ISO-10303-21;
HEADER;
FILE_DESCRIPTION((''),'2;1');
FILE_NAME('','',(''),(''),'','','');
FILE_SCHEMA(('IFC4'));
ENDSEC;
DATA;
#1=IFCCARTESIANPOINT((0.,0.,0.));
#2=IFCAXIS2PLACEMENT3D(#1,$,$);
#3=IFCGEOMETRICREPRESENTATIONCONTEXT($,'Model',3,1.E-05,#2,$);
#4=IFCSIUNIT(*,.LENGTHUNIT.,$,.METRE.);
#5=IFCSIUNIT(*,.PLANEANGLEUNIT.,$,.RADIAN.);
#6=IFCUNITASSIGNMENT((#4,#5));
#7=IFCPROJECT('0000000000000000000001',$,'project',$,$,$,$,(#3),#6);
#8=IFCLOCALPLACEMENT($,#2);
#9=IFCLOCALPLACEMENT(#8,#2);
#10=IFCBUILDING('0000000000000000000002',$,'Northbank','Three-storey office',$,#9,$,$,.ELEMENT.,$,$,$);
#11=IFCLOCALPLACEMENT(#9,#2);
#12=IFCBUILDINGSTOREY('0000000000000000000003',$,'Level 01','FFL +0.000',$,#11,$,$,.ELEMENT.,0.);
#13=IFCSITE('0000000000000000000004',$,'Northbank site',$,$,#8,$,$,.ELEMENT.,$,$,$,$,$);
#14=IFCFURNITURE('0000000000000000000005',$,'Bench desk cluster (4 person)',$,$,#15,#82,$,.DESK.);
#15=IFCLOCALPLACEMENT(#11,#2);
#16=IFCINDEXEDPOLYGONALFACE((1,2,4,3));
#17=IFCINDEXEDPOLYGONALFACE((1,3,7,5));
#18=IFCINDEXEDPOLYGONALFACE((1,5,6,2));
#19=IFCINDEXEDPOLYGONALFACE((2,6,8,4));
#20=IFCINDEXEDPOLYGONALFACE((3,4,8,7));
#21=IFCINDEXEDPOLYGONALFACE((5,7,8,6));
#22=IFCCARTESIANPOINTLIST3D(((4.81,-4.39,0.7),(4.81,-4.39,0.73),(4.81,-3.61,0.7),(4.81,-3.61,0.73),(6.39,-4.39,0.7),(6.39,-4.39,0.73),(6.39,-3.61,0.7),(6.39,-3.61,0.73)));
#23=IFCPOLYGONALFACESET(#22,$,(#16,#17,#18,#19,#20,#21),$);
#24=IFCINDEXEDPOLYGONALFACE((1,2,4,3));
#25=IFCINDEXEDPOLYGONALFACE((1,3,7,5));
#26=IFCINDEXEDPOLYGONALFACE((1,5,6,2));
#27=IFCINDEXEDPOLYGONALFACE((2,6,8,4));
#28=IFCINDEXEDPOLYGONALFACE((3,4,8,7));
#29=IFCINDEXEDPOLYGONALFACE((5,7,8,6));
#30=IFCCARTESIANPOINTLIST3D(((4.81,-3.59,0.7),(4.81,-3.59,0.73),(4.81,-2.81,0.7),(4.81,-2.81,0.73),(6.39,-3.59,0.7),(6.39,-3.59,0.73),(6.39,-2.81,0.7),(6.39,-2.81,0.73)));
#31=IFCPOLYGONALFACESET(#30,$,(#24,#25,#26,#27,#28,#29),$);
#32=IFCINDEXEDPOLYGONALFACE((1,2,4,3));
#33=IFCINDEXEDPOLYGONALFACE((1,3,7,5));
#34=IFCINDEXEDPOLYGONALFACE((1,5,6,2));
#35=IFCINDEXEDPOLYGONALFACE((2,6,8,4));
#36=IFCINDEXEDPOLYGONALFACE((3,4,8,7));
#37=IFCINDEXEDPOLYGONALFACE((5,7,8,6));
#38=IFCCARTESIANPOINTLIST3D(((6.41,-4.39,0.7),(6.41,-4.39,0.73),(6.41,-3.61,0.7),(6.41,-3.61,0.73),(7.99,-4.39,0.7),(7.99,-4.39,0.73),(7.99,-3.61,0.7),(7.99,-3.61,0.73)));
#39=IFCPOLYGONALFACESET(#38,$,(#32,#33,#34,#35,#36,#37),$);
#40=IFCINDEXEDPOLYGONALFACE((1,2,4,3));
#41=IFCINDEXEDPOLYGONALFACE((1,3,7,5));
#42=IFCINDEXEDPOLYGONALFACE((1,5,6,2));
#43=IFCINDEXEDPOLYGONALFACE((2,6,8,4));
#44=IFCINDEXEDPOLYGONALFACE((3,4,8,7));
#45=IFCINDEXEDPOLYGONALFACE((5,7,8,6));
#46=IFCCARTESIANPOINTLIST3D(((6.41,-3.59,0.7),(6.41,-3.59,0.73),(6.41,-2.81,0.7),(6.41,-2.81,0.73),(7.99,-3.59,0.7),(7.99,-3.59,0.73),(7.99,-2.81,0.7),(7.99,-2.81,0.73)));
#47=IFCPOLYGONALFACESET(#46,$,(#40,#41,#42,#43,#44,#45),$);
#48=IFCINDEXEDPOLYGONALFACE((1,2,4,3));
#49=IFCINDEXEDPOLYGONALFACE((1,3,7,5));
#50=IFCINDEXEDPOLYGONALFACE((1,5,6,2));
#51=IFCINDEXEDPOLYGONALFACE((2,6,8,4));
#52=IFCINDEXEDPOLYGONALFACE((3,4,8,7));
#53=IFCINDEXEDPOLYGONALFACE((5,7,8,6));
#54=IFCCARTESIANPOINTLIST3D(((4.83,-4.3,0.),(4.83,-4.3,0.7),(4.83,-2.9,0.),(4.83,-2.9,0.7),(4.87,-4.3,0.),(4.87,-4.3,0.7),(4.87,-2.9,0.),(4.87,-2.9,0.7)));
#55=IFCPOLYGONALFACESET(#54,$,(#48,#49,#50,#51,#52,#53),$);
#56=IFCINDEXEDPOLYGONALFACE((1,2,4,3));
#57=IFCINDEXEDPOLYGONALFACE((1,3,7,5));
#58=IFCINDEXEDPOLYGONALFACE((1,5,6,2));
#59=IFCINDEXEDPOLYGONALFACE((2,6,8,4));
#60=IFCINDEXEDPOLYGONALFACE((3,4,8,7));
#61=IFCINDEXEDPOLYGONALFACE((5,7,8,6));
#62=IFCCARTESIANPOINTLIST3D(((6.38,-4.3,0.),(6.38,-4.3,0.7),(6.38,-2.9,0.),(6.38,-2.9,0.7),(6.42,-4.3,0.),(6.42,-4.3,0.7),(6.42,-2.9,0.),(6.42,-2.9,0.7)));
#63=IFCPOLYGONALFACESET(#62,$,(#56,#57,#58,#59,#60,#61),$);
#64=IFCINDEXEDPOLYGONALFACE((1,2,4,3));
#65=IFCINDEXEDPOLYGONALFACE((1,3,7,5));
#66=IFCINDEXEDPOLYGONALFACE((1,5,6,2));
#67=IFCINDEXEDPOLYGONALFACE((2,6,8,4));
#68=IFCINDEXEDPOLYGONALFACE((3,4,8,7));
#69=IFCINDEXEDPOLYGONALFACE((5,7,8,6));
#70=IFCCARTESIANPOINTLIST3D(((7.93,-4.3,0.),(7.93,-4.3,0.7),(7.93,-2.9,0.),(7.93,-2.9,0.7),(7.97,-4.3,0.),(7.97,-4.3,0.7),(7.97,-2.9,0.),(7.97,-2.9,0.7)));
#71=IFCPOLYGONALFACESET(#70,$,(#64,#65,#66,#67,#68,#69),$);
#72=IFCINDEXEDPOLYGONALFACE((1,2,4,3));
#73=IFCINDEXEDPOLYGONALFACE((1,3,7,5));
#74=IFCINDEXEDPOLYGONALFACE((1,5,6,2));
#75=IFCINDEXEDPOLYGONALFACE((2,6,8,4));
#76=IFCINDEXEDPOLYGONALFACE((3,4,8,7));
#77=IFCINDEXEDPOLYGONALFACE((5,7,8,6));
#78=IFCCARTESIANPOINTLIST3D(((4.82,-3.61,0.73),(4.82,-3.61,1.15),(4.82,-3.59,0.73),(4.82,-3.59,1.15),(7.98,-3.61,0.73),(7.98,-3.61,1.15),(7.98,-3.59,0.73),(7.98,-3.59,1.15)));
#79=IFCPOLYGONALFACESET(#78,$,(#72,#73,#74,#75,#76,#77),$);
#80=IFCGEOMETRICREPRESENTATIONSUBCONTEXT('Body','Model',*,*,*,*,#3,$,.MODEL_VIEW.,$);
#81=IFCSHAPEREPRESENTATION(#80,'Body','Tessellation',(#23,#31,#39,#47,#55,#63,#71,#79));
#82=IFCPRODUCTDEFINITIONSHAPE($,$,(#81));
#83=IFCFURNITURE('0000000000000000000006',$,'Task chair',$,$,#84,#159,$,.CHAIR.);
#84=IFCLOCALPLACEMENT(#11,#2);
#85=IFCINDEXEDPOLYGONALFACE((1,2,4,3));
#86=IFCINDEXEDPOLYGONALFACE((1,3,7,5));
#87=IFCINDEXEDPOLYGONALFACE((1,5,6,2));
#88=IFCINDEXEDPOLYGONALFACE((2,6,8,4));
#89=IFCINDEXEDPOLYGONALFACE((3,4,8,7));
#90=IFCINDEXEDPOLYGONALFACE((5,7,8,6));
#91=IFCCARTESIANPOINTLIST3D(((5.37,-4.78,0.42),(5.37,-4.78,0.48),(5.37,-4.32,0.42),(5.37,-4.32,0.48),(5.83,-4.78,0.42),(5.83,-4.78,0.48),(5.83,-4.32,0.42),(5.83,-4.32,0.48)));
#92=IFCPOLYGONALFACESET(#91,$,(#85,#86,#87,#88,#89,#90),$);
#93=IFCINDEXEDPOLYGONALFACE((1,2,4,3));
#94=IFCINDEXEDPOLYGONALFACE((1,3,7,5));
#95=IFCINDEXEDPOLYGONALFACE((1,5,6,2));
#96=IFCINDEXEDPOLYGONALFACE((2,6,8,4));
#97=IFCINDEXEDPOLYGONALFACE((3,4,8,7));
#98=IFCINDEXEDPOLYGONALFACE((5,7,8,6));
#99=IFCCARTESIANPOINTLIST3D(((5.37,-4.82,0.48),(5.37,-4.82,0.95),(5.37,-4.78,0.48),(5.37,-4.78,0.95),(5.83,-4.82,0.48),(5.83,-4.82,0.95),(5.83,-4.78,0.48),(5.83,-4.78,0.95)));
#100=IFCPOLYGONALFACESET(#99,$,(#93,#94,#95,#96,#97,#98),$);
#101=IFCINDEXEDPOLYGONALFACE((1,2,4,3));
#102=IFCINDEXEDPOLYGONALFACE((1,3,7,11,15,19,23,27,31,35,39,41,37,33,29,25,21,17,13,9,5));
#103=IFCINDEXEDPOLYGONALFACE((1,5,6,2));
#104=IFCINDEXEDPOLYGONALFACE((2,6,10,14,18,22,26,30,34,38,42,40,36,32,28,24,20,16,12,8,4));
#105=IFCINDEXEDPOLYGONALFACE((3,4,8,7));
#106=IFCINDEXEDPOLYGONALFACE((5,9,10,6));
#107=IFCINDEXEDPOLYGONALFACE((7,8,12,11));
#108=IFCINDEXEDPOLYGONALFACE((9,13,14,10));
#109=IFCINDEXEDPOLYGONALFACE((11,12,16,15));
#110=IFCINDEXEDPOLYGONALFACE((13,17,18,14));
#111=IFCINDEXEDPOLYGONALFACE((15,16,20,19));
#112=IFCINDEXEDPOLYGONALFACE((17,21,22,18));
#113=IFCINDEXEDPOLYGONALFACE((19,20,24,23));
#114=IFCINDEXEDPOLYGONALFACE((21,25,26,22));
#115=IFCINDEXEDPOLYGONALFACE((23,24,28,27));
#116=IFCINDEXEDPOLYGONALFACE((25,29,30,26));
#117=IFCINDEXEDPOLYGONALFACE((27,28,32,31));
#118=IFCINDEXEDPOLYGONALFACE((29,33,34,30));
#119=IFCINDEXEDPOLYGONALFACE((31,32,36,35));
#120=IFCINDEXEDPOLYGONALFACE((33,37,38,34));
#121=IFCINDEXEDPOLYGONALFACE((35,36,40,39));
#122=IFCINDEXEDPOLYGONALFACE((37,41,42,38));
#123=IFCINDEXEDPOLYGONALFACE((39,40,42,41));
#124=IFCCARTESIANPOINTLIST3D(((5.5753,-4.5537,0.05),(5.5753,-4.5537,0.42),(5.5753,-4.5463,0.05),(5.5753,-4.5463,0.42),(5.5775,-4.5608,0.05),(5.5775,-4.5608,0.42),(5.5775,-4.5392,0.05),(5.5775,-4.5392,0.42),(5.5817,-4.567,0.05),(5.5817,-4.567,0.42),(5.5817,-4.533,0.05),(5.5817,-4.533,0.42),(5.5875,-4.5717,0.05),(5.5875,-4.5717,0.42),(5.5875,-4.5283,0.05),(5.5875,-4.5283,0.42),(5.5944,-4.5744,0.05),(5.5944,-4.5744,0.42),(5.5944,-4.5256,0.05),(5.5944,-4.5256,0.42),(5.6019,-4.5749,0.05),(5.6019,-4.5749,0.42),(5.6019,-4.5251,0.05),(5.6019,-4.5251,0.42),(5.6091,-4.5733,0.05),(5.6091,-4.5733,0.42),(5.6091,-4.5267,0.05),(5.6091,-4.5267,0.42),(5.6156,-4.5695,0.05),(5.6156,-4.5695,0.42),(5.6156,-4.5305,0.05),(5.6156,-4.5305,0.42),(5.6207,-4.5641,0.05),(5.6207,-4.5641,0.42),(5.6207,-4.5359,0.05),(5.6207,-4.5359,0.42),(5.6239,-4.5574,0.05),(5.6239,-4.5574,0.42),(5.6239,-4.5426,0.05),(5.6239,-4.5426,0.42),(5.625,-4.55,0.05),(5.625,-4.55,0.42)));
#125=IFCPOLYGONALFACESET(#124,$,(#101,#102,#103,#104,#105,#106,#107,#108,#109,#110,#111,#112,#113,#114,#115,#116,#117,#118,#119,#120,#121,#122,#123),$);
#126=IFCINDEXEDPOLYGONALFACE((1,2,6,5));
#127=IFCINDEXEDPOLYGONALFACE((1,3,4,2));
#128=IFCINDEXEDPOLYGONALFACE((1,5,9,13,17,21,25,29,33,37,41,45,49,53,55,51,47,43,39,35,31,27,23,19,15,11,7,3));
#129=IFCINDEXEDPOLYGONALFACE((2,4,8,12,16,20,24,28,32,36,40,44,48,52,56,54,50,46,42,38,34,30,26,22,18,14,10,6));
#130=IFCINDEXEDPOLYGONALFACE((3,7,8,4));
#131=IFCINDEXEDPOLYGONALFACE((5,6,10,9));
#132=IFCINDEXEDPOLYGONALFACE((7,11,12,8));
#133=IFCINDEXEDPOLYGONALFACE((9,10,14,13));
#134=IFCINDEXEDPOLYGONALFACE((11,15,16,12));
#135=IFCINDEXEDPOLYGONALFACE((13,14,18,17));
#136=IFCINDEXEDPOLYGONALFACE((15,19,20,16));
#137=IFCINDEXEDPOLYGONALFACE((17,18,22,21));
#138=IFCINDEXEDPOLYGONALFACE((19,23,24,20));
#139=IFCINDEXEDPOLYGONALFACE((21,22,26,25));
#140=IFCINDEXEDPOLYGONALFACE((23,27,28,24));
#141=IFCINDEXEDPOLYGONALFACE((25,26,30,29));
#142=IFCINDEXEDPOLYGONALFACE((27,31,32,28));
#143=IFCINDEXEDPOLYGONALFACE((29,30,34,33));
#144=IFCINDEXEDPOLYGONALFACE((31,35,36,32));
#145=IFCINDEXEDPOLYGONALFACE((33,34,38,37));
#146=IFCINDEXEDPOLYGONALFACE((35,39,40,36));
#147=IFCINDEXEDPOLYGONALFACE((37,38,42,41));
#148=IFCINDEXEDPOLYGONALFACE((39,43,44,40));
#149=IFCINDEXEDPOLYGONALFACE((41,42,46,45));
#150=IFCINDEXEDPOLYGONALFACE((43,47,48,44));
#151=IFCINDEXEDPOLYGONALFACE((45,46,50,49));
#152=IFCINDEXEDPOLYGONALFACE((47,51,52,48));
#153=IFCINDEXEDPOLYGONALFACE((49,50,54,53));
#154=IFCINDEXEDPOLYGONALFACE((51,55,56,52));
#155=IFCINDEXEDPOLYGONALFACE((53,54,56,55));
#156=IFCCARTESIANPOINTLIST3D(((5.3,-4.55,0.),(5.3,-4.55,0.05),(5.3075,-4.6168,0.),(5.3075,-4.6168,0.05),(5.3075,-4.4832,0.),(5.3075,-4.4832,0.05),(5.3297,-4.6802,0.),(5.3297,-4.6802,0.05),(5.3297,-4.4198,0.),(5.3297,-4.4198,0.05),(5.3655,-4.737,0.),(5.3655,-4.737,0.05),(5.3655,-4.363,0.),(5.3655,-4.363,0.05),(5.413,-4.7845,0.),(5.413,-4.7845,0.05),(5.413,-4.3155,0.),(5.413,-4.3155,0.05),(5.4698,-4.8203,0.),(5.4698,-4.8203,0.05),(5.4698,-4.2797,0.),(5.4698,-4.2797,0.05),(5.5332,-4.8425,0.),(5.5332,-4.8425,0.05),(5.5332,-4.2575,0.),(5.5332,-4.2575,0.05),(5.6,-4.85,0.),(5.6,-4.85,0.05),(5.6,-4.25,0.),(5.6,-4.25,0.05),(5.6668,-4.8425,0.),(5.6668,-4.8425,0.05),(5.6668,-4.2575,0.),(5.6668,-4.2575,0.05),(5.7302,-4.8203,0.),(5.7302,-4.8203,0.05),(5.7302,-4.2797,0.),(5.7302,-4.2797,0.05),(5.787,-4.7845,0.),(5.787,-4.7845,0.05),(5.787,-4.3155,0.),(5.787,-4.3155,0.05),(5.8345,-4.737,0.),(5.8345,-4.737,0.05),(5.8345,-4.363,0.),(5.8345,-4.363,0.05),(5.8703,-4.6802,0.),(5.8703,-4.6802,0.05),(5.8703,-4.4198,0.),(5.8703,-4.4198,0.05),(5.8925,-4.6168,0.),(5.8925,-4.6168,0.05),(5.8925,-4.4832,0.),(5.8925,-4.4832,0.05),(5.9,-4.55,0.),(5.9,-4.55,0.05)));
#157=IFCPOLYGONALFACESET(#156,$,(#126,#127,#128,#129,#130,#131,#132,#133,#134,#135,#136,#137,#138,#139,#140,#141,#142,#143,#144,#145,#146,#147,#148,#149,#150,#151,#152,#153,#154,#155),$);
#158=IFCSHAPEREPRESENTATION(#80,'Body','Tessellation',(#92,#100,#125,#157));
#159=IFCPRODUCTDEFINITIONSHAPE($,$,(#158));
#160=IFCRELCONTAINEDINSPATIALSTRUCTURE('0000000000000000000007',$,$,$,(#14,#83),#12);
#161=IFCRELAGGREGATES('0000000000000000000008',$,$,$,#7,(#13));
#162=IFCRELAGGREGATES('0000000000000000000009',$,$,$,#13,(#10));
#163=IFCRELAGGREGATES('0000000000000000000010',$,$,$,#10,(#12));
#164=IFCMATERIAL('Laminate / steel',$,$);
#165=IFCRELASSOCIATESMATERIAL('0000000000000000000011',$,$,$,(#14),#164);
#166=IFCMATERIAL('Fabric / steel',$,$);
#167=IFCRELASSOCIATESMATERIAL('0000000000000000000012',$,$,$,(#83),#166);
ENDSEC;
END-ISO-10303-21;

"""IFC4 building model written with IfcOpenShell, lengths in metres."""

from ifc_helpers import new_model, si_unit, frame, origin, place, context, subcontext, project, spatial, rectangle, circle, extrude, material, element, save


model = new_model("IFC4")

# Units and contexts
model_context = context("Model", 3, precision=1e-05, world=origin())
body_context = subcontext(model_context, "Body", "Model", "MODEL_VIEW")
ifc_project = project(units=[si_unit("LENGTHUNIT", "METRE"), si_unit("PLANEANGLEUNIT", "RADIAN")], contexts=[model_context])

# Site, building, storey
site_placement = place(None, origin())
site = spatial("IfcSite", under=ifc_project, at=site_placement, Name="Northbank site", CompositionType="ELEMENT")
building_placement = place(site_placement, origin())
building = spatial("IfcBuilding", under=site, at=building_placement, Name="Northbank", Description="Three-storey office", CompositionType="ELEMENT")
storey_placement = place(building_placement, origin())
storey = spatial("IfcBuildingStorey", under=building, at=storey_placement, Name="Level 01", Description="FFL +0.000", CompositionType="ELEMENT", Elevation=0.0)

# Furniture
ifc_material_1 = material(Name="Fabric / steel")
ifc_material_2 = material(Name="Laminate / steel")
furniture_1_placement = place(storey_placement, origin())
element("IfcFurniture", 1, at=furniture_1_placement, inside=storey, material=ifc_material_2, Name="Bench desk cluster (4 person)", PredefinedType="DESK", context=body_context, shape_type="SweptSolid", body=[
    extrude(rectangle(XDim=1.58, YDim=0.78), frame((5.6, -4.0, 0.7)), (0.0, 0.0, 1.0), 0.03),
    extrude(rectangle(XDim=1.58, YDim=0.78), frame((5.6, -3.2, 0.7)), (0.0, 0.0, 1.0), 0.03),
    extrude(rectangle(XDim=1.58, YDim=0.78), frame((7.2, -4.0, 0.7)), (0.0, 0.0, 1.0), 0.03),
    extrude(rectangle(XDim=1.58, YDim=0.78), frame((7.2, -3.2, 0.7)), (0.0, 0.0, 1.0), 0.03),
    extrude(rectangle(XDim=0.04, YDim=1.4), frame((4.85, -3.6, 0.0)), (0.0, 0.0, 1.0), 0.7),
    extrude(rectangle(XDim=0.04, YDim=1.4), frame((6.4, -3.6, 0.0)), (0.0, 0.0, 1.0), 0.7),
    extrude(rectangle(XDim=0.04, YDim=1.4), frame((7.95, -3.6, 0.0)), (0.0, 0.0, 1.0), 0.7),
    extrude(rectangle(XDim=3.16, YDim=0.02), frame((6.4, -3.6, 0.73)), (0.0, 0.0, 1.0), 0.42),
])
furniture_2_placement = place(storey_placement, origin())
element("IfcFurniture", 2, at=furniture_2_placement, inside=storey, material=ifc_material_1, Name="Task chair", PredefinedType="CHAIR", context=body_context, shape_type="SweptSolid", body=[
    extrude(rectangle(XDim=0.46, YDim=0.46), frame((5.6, -4.55, 0.42)), (0.0, 0.0, 1.0), 0.06),
    extrude(rectangle(XDim=0.46, YDim=0.04), frame((5.6, -4.8, 0.48)), (0.0, 0.0, 1.0), 0.47),
    extrude(circle(Radius=0.025), frame((5.6, -4.55, 0.05), z_axis=(0.0, 0.0, 1.0), x_axis=(1.0, 0.0, 0.0)), (0.0, 0.0, 1.0), 0.37),
    extrude(circle(Radius=0.3), frame((5.6, -4.55, 0.0), z_axis=(0.0, 0.0, 1.0), x_axis=(1.0, 0.0, 0.0)), (0.0, 0.0, 1.0), 0.05),
])

save(model, "model.ifc")
